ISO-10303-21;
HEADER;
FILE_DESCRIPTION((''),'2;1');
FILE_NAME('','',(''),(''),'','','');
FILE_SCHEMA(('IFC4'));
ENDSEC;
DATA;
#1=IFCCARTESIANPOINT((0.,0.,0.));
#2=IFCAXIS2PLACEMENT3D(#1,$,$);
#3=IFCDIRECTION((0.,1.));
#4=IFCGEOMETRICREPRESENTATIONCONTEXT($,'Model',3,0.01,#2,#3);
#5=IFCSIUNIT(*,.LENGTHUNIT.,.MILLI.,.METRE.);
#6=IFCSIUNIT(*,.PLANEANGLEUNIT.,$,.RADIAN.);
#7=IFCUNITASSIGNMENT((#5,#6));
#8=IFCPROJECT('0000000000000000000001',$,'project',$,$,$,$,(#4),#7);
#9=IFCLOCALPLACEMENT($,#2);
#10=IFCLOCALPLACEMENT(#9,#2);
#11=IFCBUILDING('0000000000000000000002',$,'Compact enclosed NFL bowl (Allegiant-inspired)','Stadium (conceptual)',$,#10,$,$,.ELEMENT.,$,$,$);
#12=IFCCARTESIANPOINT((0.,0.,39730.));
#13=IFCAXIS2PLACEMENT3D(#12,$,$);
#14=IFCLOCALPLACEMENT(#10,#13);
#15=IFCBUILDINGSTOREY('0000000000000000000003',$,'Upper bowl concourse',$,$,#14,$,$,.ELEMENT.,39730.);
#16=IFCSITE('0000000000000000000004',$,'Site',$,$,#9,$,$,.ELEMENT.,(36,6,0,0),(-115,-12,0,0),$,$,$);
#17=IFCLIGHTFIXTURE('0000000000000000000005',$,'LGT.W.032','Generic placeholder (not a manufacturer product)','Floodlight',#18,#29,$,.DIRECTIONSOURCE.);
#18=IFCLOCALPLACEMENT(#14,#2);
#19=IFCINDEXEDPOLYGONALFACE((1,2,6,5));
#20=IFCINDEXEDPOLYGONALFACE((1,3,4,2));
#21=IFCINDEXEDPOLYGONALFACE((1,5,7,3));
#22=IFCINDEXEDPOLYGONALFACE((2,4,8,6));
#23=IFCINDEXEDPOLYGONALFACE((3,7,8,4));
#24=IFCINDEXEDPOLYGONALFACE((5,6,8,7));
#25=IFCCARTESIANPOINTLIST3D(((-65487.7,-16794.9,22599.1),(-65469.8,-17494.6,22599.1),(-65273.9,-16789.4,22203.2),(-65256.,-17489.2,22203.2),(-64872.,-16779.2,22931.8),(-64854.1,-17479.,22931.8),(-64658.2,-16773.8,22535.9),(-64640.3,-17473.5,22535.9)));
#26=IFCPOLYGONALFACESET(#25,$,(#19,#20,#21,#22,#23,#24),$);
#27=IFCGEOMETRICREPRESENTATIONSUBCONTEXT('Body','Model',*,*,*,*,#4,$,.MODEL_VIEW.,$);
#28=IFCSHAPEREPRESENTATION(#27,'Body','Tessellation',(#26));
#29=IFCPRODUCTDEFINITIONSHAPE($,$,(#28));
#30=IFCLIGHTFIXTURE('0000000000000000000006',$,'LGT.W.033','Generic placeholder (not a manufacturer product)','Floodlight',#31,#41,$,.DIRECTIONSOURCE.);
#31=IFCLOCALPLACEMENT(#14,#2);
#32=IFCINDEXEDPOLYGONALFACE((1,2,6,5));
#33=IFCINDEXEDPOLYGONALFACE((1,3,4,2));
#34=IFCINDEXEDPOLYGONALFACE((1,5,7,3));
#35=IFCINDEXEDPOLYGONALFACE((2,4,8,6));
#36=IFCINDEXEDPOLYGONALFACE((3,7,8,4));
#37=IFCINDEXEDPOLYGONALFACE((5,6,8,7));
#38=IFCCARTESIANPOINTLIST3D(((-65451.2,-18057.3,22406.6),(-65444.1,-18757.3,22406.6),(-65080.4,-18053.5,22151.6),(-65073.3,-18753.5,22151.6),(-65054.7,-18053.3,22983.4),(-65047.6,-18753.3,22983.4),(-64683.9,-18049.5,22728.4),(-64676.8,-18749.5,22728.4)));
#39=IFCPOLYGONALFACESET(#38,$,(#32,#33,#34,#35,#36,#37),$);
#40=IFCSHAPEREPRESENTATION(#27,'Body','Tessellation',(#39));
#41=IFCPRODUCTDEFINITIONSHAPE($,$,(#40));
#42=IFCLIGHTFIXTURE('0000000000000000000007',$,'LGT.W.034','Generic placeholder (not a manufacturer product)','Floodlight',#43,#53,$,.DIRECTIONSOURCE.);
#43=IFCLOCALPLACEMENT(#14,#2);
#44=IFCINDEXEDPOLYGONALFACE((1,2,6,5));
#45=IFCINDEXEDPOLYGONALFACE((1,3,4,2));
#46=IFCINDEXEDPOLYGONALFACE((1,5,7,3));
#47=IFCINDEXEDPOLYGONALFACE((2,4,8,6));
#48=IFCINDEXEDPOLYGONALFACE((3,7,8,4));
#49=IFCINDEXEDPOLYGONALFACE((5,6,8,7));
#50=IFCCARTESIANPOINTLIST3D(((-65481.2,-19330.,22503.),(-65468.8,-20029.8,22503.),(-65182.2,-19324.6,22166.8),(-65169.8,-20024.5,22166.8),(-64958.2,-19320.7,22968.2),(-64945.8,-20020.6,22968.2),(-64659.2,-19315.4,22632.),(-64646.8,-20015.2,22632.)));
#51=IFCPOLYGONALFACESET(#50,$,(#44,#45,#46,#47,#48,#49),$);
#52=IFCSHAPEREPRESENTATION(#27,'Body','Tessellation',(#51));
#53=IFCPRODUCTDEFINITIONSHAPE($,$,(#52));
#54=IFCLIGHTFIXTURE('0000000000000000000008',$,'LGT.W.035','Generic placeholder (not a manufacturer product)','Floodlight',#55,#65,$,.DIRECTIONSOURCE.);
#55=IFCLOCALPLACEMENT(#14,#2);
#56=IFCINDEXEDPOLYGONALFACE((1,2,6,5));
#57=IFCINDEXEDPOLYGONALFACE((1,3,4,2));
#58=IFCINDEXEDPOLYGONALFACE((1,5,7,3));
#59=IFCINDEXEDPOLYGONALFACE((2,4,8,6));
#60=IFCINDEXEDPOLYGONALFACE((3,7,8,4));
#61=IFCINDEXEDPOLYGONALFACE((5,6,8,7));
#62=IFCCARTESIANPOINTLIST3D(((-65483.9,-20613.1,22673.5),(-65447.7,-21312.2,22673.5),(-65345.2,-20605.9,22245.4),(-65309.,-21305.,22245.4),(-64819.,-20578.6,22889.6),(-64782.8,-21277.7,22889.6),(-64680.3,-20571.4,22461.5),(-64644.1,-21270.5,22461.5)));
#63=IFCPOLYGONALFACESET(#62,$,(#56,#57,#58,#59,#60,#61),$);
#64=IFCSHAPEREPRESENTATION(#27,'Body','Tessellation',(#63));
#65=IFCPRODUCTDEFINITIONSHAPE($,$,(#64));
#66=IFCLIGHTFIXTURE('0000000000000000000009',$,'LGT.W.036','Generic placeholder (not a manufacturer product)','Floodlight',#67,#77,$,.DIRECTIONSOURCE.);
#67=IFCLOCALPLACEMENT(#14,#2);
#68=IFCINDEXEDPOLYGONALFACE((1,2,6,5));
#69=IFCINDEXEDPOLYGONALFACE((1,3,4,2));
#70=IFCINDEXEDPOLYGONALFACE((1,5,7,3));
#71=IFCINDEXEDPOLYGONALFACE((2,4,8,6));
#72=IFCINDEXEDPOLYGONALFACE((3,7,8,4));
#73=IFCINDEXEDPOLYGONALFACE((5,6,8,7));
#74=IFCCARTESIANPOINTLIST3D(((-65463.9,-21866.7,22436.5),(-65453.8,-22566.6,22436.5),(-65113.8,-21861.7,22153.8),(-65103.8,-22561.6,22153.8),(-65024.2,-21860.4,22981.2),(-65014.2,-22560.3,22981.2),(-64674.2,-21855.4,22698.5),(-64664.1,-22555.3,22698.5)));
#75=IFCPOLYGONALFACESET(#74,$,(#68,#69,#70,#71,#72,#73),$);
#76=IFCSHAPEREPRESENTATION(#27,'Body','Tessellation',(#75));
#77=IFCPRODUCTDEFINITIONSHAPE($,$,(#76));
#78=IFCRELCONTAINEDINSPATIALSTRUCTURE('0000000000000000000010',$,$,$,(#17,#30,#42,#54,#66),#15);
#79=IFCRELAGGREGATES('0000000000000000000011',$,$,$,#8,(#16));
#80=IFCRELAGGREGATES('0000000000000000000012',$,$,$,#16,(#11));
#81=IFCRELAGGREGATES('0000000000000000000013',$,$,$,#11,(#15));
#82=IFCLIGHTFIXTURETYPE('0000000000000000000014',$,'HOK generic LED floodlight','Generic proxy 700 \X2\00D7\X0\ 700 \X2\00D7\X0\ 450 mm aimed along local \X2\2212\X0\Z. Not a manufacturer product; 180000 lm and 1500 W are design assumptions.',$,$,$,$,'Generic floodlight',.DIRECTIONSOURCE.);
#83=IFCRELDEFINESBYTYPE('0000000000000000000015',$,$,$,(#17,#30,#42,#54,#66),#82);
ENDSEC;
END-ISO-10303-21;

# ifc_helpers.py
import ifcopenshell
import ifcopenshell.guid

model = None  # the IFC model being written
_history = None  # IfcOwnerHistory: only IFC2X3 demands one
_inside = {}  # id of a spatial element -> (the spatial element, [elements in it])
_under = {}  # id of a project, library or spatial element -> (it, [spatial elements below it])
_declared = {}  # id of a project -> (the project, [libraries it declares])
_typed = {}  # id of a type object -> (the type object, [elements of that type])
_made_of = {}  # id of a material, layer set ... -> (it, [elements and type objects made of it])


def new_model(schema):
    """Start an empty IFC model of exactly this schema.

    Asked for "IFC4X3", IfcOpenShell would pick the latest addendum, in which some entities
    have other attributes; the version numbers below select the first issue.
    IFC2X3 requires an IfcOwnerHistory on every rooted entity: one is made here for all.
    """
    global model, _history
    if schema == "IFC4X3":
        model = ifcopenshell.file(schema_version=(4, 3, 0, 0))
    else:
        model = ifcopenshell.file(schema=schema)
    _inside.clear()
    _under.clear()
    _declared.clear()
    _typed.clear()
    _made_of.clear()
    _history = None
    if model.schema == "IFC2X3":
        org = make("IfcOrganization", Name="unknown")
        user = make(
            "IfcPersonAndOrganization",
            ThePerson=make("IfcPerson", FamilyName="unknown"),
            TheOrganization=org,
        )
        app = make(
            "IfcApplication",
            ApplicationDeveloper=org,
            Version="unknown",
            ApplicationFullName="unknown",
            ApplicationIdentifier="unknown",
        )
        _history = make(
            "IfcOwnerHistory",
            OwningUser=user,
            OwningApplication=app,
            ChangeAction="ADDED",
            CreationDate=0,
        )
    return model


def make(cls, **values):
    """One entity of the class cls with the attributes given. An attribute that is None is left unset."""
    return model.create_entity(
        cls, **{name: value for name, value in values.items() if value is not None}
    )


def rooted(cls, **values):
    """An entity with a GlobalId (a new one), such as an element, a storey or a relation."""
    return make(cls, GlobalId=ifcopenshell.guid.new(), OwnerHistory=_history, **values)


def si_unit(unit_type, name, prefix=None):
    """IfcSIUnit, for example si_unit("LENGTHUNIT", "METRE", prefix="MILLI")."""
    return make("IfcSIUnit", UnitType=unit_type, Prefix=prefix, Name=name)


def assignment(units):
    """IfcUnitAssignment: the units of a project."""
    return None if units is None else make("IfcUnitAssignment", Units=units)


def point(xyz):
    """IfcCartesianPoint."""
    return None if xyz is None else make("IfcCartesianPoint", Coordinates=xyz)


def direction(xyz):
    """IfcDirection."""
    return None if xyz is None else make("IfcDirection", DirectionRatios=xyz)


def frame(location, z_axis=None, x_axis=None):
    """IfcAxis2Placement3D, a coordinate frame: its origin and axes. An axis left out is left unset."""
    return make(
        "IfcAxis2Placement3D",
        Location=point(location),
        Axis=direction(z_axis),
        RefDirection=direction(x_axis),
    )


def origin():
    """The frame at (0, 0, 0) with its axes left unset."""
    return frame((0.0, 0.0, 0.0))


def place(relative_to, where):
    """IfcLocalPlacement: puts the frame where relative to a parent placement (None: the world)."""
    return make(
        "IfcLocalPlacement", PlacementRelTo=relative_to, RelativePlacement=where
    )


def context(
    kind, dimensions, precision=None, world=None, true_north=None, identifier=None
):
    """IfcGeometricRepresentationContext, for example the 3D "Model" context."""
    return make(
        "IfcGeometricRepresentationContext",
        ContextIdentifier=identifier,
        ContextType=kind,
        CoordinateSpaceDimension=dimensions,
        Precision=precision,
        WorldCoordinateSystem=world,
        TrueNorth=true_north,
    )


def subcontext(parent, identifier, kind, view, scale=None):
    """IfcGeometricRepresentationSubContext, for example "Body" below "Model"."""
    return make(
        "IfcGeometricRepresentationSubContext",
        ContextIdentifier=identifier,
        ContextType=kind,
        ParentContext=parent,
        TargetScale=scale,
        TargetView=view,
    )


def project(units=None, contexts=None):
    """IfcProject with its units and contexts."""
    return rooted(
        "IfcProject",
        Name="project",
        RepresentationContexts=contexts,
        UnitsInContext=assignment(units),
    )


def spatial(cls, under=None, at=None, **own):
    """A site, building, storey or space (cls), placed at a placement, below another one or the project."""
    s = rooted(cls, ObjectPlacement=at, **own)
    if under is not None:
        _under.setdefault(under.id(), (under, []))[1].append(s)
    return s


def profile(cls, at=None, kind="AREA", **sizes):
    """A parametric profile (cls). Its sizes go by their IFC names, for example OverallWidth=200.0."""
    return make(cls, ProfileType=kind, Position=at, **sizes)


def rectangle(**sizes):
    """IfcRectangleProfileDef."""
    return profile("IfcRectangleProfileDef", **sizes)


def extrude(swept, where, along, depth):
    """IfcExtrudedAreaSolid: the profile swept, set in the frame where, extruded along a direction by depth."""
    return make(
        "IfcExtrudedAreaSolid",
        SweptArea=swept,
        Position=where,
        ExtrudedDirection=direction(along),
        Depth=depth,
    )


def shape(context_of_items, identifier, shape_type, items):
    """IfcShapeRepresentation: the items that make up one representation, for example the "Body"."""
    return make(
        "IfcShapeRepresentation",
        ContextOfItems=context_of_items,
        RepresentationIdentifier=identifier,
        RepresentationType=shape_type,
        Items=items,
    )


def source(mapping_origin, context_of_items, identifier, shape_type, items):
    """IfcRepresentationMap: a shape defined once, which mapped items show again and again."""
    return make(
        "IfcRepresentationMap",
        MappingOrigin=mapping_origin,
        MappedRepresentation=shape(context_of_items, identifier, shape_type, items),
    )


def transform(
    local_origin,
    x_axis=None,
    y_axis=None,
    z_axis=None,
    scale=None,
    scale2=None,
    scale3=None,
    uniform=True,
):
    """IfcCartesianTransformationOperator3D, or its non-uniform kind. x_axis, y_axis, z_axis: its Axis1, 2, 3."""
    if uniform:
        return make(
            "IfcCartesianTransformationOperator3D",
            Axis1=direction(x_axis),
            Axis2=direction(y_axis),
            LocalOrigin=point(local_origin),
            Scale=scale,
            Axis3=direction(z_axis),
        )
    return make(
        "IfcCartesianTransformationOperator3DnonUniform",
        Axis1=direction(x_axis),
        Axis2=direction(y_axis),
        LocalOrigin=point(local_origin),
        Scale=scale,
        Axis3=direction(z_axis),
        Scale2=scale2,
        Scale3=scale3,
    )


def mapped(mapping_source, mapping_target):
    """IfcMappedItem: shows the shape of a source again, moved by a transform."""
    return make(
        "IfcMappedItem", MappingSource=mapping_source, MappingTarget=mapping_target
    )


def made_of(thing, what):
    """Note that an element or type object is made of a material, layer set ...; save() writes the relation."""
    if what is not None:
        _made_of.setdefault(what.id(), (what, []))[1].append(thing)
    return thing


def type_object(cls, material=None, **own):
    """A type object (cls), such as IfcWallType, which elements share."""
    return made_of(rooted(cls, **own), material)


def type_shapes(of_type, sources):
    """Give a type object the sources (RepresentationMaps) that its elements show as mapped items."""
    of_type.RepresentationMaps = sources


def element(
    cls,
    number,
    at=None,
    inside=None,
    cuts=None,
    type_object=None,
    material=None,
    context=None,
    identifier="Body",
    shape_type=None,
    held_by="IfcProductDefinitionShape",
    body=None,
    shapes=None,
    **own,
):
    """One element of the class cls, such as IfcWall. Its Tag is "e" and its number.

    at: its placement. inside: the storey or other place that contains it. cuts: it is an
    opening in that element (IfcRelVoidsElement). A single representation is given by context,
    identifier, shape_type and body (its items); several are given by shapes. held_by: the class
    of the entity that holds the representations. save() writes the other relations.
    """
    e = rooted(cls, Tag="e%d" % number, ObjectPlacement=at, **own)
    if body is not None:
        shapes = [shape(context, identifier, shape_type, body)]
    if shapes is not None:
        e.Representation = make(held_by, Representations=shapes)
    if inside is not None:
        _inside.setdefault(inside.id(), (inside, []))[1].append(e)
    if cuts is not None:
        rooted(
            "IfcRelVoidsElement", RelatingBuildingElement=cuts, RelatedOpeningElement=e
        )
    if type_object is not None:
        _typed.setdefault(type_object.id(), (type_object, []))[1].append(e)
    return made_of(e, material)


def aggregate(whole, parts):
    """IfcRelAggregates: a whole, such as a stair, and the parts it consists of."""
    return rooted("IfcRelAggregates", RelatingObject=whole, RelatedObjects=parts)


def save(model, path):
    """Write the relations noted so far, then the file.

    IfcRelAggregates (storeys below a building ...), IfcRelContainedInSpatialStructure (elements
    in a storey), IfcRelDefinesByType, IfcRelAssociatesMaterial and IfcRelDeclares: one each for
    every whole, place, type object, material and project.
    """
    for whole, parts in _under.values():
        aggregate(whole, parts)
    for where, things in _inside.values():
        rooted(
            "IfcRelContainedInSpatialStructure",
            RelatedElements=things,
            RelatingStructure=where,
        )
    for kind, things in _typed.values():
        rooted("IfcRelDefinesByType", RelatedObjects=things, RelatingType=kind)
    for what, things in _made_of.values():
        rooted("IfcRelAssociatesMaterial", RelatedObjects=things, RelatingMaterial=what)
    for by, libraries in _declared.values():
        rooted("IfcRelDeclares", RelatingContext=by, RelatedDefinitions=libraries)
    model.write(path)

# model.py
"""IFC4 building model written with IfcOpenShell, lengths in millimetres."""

from ifc_helpers import new_model, si_unit, direction, frame, origin, place, context, subcontext, project, spatial, rectangle, extrude, source, transform, mapped, type_object, type_shapes, element, save


model = new_model("IFC4")

# Units and contexts
model_context = context("Model", 3, precision=0.01, world=origin(), true_north=direction((0.0, 1.0)))
body_context = subcontext(model_context, "Body", "Model", "MODEL_VIEW")
ifc_project = project(units=[si_unit("LENGTHUNIT", "METRE", prefix="MILLI"), si_unit("PLANEANGLEUNIT", "RADIAN")], contexts=[model_context])

# Site, building, storey
site_placement = place(None, origin())
site = spatial("IfcSite", under=ifc_project, at=site_placement, Name="Site", CompositionType="ELEMENT", RefLatitude=(36, 6, 0, 0), RefLongitude=(-115, -12, 0, 0))
building_placement = place(site_placement, origin())
building = spatial("IfcBuilding", under=site, at=building_placement, Name="Compact enclosed NFL bowl (Allegiant-inspired)", Description="Stadium (conceptual)", CompositionType="ELEMENT")
storey_placement = place(building_placement, frame((0.0, 0.0, 39730.0)))
storey = spatial("IfcBuildingStorey", under=building, at=storey_placement, Name="Upper bowl concourse", CompositionType="ELEMENT", Elevation=39730.0)

# Light fixtures
light_fixture_type = type_object("IfcLightFixtureType", Name="HOK generic LED floodlight", Description="Generic proxy 700 × 700 × 450 mm aimed along local −Z. Not a manufacturer product; 180000 lm and 1500 W are design assumptions.", ElementType="Generic floodlight", PredefinedType="DIRECTIONSOURCE")
shared_shape = source(origin(), body_context, "Body", "SweptSolid", [
    extrude(rectangle(XDim=700.0, YDim=700.0), frame((0.0, 0.0, -225.0)), (0.0, 0.0, 1.0), 450.0),
])
type_shapes(light_fixture_type, [shared_shape])
for number, where, z_axis, x_axis, name in (
    (1, (-65064.0, -17134.2, 22567.5), (-0.47509, -0.0121, 0.879854), (0.02546, -0.999676, 0.0), "LGT.W.032"),
    (2, (-65064.0, -18403.4, 22567.5), (-0.823981, -0.008368, 0.566555), (0.010155, -0.999948, 0.0), "LGT.W.033"),
    (3, (-65064.0, -19672.6, 22567.5), (-0.664463, -0.011798, 0.747228), (0.017753, -0.999842, 0.0), "LGT.W.034"),
    (4, (-65064.0, -20941.8, 22567.5), (-0.308275, -0.015987, 0.951163), (0.05179, -0.998658, 0.0), "LGT.W.035"),
    (5, (-65064.0, -22211.0, 22567.5), (-0.777995, -0.011198, 0.628171), (0.014392, -0.999896, 0.0), "LGT.W.036"),
):
    element("IfcLightFixture", number, at=place(storey_placement, frame(where, z_axis=z_axis, x_axis=x_axis)), inside=storey, type_object=light_fixture_type, Name=name, Description="Generic placeholder (not a manufacturer product)", ObjectType="Floodlight", PredefinedType="DIRECTIONSOURCE", context=body_context, shape_type="MappedRepresentation", body=[
        mapped(shared_shape, transform((0.0, 0.0, 0.0))),
    ])

save(model, "model.ifc")
